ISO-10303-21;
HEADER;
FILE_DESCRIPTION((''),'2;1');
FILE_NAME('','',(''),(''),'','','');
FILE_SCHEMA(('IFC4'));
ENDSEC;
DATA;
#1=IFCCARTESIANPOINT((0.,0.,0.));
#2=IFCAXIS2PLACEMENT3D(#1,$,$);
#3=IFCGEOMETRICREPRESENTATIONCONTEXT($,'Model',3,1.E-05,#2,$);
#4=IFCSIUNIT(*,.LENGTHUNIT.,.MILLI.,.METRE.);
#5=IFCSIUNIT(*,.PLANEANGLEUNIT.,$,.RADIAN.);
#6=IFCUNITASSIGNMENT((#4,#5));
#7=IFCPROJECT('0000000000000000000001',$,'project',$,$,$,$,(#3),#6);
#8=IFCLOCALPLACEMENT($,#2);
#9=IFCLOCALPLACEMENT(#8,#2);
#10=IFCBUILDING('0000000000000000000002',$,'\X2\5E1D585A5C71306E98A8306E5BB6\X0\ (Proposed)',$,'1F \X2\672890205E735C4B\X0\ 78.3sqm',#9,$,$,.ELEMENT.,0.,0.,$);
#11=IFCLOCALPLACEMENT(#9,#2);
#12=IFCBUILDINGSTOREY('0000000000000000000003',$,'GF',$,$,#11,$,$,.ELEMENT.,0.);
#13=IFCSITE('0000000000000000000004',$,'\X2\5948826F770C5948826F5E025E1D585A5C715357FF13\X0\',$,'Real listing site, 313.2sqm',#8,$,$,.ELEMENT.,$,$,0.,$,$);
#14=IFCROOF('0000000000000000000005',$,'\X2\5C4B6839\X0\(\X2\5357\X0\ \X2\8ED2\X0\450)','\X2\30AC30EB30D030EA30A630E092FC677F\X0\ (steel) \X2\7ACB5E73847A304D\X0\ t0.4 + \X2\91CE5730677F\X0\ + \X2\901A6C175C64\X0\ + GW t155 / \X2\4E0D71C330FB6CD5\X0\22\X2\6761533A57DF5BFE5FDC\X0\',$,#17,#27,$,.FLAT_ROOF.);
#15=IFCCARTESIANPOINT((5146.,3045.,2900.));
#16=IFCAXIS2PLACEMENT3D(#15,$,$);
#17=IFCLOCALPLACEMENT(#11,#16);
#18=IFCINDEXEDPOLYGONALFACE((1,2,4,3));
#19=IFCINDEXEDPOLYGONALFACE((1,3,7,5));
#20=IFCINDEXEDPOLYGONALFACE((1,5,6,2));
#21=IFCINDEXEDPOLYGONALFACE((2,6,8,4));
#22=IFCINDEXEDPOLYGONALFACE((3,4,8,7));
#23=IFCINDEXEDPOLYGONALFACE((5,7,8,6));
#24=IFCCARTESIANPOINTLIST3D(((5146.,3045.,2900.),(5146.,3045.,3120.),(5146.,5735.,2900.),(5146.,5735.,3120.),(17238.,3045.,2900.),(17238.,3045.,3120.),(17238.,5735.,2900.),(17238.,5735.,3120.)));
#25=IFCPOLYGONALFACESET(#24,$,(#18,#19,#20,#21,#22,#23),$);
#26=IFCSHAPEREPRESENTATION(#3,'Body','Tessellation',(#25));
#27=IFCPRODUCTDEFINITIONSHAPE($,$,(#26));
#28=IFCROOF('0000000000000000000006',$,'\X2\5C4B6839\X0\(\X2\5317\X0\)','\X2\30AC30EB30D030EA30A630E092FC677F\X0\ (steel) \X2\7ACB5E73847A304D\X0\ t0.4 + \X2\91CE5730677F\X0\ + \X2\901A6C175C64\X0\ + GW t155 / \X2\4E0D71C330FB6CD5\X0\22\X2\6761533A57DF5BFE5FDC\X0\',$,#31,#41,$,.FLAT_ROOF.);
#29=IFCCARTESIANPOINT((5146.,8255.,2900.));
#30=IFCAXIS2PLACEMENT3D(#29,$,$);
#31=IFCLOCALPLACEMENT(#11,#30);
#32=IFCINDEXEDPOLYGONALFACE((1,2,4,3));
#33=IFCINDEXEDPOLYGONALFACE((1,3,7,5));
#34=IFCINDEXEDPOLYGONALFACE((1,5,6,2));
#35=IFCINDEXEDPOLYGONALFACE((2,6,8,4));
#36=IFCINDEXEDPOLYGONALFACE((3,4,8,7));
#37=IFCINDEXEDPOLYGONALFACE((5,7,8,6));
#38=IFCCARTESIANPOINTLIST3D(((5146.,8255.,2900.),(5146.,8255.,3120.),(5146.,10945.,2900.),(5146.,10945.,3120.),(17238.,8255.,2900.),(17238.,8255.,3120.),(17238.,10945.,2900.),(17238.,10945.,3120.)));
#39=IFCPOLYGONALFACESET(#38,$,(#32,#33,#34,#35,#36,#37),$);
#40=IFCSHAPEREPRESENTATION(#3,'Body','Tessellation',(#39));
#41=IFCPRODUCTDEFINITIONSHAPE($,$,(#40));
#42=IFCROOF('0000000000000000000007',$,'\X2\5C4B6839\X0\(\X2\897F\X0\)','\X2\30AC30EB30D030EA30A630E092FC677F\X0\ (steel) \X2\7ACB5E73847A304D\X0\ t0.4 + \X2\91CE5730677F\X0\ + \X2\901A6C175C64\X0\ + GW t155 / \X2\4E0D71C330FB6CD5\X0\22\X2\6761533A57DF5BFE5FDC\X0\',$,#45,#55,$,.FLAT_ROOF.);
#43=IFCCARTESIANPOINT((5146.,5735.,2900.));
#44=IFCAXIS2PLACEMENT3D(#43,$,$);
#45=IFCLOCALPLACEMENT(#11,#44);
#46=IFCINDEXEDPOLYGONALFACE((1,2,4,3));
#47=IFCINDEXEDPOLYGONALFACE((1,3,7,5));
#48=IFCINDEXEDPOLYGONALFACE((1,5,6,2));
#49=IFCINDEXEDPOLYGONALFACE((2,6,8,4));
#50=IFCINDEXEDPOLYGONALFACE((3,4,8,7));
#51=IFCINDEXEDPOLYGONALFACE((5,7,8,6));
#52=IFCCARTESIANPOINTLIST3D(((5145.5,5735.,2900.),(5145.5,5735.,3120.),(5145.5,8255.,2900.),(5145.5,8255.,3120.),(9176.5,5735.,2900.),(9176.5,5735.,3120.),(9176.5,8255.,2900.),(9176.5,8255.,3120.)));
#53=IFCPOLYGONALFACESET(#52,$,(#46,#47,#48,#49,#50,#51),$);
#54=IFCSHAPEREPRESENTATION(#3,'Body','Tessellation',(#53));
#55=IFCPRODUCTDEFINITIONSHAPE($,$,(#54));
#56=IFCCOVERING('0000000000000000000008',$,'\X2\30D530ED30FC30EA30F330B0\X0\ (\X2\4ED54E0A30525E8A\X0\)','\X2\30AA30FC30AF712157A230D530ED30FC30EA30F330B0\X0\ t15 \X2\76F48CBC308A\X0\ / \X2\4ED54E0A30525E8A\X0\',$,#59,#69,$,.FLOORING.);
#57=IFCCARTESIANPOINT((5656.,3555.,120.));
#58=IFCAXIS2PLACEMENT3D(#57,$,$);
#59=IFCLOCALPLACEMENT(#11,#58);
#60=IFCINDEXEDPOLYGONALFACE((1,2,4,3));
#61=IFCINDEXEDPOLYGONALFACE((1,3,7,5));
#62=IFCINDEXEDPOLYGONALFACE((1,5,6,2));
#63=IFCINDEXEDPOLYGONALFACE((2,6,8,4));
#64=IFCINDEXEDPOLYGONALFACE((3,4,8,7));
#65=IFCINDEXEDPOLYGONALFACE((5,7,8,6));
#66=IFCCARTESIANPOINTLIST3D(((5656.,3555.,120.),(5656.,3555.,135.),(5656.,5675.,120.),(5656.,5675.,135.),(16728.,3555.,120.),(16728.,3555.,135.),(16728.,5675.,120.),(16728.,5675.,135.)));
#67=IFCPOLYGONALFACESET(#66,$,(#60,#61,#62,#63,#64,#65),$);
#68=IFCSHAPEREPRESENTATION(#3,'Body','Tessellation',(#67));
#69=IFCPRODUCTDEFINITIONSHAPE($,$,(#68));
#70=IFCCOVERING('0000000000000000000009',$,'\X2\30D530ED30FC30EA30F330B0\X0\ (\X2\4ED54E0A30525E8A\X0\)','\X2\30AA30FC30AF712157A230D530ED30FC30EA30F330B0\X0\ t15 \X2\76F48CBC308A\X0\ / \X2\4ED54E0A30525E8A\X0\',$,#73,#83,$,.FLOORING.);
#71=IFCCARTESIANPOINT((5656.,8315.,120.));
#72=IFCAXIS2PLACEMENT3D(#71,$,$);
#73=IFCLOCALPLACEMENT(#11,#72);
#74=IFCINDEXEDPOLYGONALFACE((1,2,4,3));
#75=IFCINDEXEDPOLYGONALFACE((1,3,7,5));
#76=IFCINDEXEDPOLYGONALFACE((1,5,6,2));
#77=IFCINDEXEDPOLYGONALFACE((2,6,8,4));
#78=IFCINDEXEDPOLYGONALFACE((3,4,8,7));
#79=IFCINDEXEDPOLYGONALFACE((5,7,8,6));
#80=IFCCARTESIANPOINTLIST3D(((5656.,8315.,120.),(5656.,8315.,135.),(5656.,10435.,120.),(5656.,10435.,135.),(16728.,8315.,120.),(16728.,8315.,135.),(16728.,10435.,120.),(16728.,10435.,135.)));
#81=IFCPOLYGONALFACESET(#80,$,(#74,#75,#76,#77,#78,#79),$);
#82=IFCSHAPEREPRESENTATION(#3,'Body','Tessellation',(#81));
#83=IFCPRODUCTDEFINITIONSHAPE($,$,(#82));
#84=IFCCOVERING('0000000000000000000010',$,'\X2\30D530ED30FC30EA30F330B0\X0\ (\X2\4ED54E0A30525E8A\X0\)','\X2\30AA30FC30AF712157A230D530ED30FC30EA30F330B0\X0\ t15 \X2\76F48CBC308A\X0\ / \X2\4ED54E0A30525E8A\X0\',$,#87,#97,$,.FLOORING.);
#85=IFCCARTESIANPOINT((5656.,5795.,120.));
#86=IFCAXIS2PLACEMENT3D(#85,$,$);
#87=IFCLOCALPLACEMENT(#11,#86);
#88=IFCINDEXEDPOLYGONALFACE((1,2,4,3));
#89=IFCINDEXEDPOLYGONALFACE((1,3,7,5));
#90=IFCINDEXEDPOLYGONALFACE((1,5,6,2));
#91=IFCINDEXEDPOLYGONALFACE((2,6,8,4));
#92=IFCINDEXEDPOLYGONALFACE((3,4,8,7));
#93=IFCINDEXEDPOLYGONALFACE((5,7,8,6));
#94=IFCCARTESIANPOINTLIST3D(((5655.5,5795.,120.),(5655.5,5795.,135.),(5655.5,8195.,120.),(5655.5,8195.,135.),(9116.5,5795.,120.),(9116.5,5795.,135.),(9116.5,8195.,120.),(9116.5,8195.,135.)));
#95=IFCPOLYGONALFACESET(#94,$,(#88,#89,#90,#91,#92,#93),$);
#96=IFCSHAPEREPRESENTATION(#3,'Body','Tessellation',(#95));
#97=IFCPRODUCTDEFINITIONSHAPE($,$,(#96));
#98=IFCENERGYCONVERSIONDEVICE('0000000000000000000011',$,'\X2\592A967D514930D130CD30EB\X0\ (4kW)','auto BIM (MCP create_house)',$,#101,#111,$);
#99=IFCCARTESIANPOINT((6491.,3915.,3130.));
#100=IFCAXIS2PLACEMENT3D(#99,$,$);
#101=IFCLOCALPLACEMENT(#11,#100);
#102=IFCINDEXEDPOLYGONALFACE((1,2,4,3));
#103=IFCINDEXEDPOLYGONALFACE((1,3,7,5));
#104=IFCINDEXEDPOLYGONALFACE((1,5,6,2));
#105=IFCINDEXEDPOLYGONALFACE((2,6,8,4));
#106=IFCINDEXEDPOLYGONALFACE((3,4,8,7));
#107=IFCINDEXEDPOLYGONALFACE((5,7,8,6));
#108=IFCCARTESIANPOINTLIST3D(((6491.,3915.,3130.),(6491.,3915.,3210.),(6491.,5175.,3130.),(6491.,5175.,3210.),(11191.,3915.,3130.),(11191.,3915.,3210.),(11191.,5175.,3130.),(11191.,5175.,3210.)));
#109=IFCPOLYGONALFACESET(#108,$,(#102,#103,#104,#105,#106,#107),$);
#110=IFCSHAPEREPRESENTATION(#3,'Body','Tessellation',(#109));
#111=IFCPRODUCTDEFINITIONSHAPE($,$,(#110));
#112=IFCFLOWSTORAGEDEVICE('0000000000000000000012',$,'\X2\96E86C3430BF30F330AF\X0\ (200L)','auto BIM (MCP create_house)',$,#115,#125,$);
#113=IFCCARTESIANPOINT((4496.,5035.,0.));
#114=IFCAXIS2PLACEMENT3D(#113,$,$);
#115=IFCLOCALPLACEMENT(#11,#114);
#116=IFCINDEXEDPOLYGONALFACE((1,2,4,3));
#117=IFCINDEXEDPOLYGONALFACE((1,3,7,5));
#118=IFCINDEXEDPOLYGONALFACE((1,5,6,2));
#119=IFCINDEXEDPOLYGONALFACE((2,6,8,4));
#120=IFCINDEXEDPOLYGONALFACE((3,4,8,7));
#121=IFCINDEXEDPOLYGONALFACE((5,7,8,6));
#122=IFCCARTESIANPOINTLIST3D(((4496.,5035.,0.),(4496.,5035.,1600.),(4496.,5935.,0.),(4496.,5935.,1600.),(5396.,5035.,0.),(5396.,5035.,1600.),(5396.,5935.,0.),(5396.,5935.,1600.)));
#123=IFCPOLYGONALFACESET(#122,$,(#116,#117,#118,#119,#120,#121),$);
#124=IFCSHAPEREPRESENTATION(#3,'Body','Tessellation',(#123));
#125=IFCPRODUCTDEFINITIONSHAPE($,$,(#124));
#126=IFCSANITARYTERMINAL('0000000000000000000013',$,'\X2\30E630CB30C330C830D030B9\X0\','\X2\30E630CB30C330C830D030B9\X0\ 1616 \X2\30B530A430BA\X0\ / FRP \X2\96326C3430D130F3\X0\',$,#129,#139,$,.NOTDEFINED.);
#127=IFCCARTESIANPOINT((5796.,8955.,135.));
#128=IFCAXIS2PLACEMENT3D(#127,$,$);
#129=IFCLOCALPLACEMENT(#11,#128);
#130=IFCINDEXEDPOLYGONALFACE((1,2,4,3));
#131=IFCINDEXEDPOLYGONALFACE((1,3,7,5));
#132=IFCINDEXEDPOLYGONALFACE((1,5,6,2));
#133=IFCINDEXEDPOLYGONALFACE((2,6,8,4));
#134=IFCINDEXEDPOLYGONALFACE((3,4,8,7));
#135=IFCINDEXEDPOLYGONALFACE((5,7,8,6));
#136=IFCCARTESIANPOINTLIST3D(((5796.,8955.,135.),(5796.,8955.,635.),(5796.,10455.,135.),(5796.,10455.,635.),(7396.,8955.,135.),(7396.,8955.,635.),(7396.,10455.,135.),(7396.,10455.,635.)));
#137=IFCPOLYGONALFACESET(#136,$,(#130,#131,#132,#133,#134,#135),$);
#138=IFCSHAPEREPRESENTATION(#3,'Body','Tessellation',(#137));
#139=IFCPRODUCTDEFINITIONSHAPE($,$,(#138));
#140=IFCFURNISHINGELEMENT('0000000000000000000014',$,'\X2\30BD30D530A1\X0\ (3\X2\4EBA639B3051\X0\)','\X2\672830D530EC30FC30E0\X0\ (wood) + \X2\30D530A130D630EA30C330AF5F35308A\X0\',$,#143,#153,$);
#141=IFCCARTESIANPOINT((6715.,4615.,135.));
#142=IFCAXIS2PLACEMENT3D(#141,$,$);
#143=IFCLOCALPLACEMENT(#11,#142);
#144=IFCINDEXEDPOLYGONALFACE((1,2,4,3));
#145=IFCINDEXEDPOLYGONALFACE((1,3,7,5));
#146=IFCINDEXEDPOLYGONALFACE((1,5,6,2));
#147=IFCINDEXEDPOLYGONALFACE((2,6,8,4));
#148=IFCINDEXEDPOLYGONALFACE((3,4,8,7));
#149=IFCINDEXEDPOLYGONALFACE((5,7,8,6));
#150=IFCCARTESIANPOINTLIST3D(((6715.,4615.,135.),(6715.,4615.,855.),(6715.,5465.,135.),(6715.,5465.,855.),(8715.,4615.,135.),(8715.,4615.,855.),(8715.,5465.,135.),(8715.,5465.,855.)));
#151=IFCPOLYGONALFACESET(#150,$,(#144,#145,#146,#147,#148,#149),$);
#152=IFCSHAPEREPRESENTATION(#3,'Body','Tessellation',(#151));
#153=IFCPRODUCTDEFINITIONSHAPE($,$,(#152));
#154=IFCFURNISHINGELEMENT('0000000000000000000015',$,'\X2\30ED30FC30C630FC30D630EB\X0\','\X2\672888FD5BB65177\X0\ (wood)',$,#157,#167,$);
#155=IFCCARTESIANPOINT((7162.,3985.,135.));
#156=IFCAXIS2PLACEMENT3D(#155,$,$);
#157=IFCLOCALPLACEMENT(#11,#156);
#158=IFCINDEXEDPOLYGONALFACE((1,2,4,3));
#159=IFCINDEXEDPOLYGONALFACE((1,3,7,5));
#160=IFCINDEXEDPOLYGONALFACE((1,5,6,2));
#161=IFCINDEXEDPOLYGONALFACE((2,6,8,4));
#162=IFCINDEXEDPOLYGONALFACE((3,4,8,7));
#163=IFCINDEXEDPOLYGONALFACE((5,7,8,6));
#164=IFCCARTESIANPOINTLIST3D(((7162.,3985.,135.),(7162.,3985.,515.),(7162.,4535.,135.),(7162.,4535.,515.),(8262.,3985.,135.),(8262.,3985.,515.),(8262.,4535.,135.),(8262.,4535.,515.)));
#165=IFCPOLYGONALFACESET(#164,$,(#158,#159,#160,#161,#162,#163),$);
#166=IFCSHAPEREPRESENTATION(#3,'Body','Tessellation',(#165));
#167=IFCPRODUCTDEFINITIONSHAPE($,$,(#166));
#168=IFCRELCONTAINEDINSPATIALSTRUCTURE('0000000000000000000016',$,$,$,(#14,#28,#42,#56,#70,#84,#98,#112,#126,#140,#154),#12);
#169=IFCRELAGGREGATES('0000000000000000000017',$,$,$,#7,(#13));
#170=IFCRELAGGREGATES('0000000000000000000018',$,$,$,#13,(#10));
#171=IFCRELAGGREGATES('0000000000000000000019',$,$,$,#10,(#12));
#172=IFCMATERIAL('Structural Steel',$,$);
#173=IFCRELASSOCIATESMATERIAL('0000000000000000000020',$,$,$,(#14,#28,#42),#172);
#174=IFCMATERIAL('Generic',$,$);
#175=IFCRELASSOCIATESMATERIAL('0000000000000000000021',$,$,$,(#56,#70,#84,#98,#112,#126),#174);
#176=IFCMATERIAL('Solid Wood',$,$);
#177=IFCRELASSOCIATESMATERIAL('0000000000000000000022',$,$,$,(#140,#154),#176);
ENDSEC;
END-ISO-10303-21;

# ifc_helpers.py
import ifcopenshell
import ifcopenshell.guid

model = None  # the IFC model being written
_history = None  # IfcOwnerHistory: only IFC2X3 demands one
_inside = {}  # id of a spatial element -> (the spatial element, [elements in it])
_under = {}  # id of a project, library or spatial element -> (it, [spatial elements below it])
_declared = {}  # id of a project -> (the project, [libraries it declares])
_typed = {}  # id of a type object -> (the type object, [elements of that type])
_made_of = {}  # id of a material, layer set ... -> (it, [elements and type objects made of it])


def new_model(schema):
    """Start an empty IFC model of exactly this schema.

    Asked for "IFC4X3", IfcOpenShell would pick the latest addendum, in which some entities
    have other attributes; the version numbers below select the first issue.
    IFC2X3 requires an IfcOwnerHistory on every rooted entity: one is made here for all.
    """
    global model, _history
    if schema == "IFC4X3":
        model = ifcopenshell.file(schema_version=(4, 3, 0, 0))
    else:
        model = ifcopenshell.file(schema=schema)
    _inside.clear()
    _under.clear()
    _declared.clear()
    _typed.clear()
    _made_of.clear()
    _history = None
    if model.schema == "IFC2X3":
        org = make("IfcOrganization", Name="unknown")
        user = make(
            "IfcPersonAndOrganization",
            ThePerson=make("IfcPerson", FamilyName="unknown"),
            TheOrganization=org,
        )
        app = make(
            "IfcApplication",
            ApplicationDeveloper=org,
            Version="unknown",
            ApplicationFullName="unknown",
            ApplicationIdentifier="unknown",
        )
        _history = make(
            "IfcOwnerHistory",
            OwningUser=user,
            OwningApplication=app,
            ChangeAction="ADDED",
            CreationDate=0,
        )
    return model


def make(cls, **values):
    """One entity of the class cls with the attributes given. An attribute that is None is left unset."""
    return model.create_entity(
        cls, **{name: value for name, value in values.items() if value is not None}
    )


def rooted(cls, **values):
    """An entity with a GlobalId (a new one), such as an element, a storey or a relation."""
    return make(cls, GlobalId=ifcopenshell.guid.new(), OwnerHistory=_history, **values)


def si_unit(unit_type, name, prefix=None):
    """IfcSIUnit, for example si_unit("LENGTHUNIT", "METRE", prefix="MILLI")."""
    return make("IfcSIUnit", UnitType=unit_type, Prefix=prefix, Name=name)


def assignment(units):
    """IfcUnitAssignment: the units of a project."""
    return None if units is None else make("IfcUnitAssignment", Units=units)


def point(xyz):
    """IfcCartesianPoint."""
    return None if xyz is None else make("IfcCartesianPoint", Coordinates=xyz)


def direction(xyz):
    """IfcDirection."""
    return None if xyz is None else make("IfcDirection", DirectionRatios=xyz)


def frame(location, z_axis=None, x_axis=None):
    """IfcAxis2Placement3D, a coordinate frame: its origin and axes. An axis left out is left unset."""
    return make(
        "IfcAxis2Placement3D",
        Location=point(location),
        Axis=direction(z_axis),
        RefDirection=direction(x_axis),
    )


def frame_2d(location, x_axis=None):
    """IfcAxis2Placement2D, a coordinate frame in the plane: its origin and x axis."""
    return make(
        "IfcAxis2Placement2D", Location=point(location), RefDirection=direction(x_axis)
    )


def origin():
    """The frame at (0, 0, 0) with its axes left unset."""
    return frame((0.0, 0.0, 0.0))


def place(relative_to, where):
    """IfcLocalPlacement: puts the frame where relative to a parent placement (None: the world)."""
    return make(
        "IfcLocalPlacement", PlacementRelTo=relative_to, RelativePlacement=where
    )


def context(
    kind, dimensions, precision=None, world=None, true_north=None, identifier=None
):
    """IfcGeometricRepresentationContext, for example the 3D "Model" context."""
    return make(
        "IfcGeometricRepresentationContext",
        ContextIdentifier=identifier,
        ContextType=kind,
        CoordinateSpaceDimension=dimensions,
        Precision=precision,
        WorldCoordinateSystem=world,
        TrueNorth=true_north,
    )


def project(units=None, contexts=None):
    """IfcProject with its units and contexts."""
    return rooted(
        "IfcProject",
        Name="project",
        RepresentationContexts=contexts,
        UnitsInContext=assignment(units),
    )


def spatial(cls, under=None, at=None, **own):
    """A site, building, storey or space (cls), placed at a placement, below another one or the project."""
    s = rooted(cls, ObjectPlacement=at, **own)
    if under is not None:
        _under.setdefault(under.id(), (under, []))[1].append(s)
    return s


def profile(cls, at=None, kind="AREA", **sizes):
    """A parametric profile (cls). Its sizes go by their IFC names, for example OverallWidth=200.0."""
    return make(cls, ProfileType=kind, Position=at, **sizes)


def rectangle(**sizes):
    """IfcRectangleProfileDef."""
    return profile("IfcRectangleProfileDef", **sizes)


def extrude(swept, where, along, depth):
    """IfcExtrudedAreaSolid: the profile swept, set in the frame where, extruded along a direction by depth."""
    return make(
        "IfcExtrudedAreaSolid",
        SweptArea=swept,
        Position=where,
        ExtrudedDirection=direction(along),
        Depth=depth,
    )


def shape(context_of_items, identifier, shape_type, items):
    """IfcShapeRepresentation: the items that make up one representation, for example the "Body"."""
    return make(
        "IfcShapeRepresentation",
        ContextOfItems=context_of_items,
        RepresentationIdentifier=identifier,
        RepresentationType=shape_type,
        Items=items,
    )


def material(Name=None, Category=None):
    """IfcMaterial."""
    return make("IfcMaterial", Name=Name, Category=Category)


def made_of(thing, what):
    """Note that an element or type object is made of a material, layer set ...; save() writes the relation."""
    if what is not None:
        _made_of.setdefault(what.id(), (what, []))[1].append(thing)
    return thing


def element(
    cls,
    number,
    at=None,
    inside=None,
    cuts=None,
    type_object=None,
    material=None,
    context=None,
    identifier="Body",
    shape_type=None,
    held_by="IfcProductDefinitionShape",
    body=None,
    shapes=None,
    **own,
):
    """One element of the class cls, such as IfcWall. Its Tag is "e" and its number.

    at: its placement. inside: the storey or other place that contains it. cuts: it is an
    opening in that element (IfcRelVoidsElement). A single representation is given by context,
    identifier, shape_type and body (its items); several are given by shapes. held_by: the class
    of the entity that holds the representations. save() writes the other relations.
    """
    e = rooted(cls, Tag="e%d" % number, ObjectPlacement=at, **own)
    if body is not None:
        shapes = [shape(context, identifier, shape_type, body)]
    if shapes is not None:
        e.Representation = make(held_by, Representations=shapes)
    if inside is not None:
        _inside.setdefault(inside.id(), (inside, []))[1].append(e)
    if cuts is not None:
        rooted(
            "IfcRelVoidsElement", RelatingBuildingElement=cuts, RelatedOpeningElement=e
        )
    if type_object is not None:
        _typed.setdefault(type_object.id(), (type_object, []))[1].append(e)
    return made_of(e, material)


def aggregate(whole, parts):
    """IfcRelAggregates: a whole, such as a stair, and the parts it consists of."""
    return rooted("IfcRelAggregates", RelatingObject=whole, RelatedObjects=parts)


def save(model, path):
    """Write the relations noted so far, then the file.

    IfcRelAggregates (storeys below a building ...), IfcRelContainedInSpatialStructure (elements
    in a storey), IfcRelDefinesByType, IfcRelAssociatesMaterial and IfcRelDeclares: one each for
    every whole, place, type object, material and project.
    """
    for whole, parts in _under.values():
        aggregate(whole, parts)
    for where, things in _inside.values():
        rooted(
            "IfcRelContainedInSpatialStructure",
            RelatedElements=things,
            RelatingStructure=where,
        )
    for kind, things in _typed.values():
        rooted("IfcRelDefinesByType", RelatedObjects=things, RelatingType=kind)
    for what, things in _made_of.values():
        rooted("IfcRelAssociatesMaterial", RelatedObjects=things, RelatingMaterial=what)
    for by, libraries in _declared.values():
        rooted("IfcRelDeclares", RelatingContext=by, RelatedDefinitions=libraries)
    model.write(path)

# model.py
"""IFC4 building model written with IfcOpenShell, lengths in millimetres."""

from ifc_helpers import new_model, si_unit, frame, frame_2d, origin, place, context, project, spatial, rectangle, extrude, material, element, save


model = new_model("IFC4")

# Units and contexts
model_context = context("Model", 3, precision=1e-05, world=origin())
ifc_project = project(units=[si_unit("LENGTHUNIT", "METRE", prefix="MILLI"), si_unit("PLANEANGLEUNIT", "RADIAN")], contexts=[model_context])

# Site, building, storey
site_placement = place(None, origin())
site = spatial("IfcSite", under=ifc_project, at=site_placement, Name="奈良県奈良市帝塚山南３", ObjectType="Real listing site, 313.2sqm", CompositionType="ELEMENT", RefElevation=0.0)
building_placement = place(site_placement, origin())
building = spatial("IfcBuilding", under=site, at=building_placement, Name="帝塚山の風の家 (Proposed)", ObjectType="1F 木造平屋 78.3sqm", CompositionType="ELEMENT", ElevationOfRefHeight=0.0, ElevationOfTerrain=0.0)
storey_placement = place(building_placement, origin())
storey = spatial("IfcBuildingStorey", under=building, at=storey_placement, Name="GF", CompositionType="ELEMENT", Elevation=0.0)

# Shared definitions
ifc_material_1 = material(Name="Solid Wood")

# Roofs
ifc_material_2 = material(Name="Structural Steel")
roof_1_placement = place(storey_placement, frame((5146.0, 3045.0, 2900.0)))
element("IfcRoof", 1, at=roof_1_placement, inside=storey, material=ifc_material_2, Name="屋根(南 軒450)", Description="ガルバリウム鋼板 (steel) 立平葺き t0.4 + 野地板 + 通気層 + GW t155 / 不燃・法22条区域対応", PredefinedType="FLAT_ROOF", context=model_context, shape_type="SweptSolid", body=[
    extrude(rectangle(XDim=12092.0, YDim=2690.0, at=frame_2d((6046.0, 1345.0))), frame((5146.0, 3045.0, 2900.0)), (0.0, 0.0, 1.0), 220.0),
])
roof_2_placement = place(storey_placement, frame((5146.0, 8255.0, 2900.0)))
element("IfcRoof", 2, at=roof_2_placement, inside=storey, material=ifc_material_2, Name="屋根(北)", Description="ガルバリウム鋼板 (steel) 立平葺き t0.4 + 野地板 + 通気層 + GW t155 / 不燃・法22条区域対応", PredefinedType="FLAT_ROOF", context=model_context, shape_type="SweptSolid", body=[
    extrude(rectangle(XDim=12092.0, YDim=2690.0, at=frame_2d((6046.0, 1345.0))), frame((5146.0, 8255.0, 2900.0)), (0.0, 0.0, 1.0), 220.0),
])
roof_3_placement = place(storey_placement, frame((5146.0, 5735.0, 2900.0)))
element("IfcRoof", 3, at=roof_3_placement, inside=storey, material=ifc_material_2, Name="屋根(西)", Description="ガルバリウム鋼板 (steel) 立平葺き t0.4 + 野地板 + 通気層 + GW t155 / 不燃・法22条区域対応", PredefinedType="FLAT_ROOF", context=model_context, shape_type="SweptSolid", body=[
    extrude(rectangle(XDim=4031.0, YDim=2520.0, at=frame_2d((2015.0, 1260.0))), frame((5146.0, 5735.0, 2900.0)), (0.0, 0.0, 1.0), 220.0),
])

# Coverings
ifc_material_3 = material(Name="Generic")
covering_1_placement = place(storey_placement, frame((5656.0, 3555.0, 120.0)))
element("IfcCovering", 4, at=covering_1_placement, inside=storey, material=ifc_material_3, Name="フローリング (仕上げ床)", Description="オーク無垢フローリング t15 直貼り / 仕上げ床", PredefinedType="FLOORING", context=model_context, shape_type="SweptSolid", body=[
    extrude(rectangle(XDim=11072.0, YDim=2120.0, at=frame_2d((5536.0, 1060.0))), frame((5656.0, 3555.0, 120.0)), (0.0, 0.0, 1.0), 15.0),
])
covering_2_placement = place(storey_placement, frame((5656.0, 8315.0, 120.0)))
element("IfcCovering", 5, at=covering_2_placement, inside=storey, material=ifc_material_3, Name="フローリング (仕上げ床)", Description="オーク無垢フローリング t15 直貼り / 仕上げ床", PredefinedType="FLOORING", context=model_context, shape_type="SweptSolid", body=[
    extrude(rectangle(XDim=11072.0, YDim=2120.0, at=frame_2d((5536.0, 1060.0))), frame((5656.0, 8315.0, 120.0)), (0.0, 0.0, 1.0), 15.0),
])
covering_3_placement = place(storey_placement, frame((5656.0, 5795.0, 120.0)))
element("IfcCovering", 6, at=covering_3_placement, inside=storey, material=ifc_material_3, Name="フローリング (仕上げ床)", Description="オーク無垢フローリング t15 直貼り / 仕上げ床", PredefinedType="FLOORING", context=model_context, shape_type="SweptSolid", body=[
    extrude(rectangle(XDim=3461.0, YDim=2400.0, at=frame_2d((1730.0, 1200.0))), frame((5656.0, 5795.0, 120.0)), (0.0, 0.0, 1.0), 15.0),
])

# Energy conversion device
energy_conversion_device_placement = place(storey_placement, frame((6491.0, 3915.0, 3130.0)))
element("IfcEnergyConversionDevice", 7, at=energy_conversion_device_placement, inside=storey, material=ifc_material_3, Name="太陽光パネル (4kW)", Description="auto BIM (MCP create_house)", context=model_context, shape_type="SweptSolid", body=[
    extrude(rectangle(XDim=4700.0, YDim=1260.0, at=frame_2d((2350.0, 630.0))), frame((6491.0, 3915.0, 3130.0)), (0.0, 0.0, 1.0), 80.0),
])

# Flow storage device
flow_storage_device_placement = place(storey_placement, frame((4496.0, 5035.0, 0.0)))
element("IfcFlowStorageDevice", 8, at=flow_storage_device_placement, inside=storey, material=ifc_material_3, Name="雨水タンク (200L)", Description="auto BIM (MCP create_house)", context=model_context, shape_type="SweptSolid", body=[
    extrude(rectangle(XDim=900.0, YDim=900.0, at=frame_2d((450.0, 450.0))), frame((4496.0, 5035.0, 0.0)), (0.0, 0.0, 1.0), 1600.0),
])

# Sanitary terminal
sanitary_terminal_placement = place(storey_placement, frame((5796.0, 8955.0, 135.0)))
element("IfcSanitaryTerminal", 9, at=sanitary_terminal_placement, inside=storey, material=ifc_material_3, Name="ユニットバス", Description="ユニットバス 1616 サイズ / FRP 防水パン", PredefinedType="NOTDEFINED", context=model_context, shape_type="SweptSolid", body=[
    extrude(rectangle(XDim=1600.0, YDim=1500.0, at=frame_2d((800.0, 750.0))), frame((5796.0, 8955.0, 135.0)), (0.0, 0.0, 1.0), 500.0),
])

# Furnishing elements
furnishing_1_placement = place(storey_placement, frame((6715.0, 4615.0, 135.0)))
element("IfcFurnishingElement", 10, at=furnishing_1_placement, inside=storey, material=ifc_material_1, Name="ソファ (3人掛け)", Description="木フレーム (wood) + ファブリック張り", context=model_context, shape_type="SweptSolid", body=[
    extrude(rectangle(XDim=2000.0, YDim=850.0, at=frame_2d((1000.0, 425.0))), frame((6715.0, 4615.0, 135.0)), (0.0, 0.0, 1.0), 720.0),
])
furnishing_2_placement = place(storey_placement, frame((7162.0, 3985.0, 135.0)))
element("IfcFurnishingElement", 11, at=furnishing_2_placement, inside=storey, material=ifc_material_1, Name="ローテーブル", Description="木製家具 (wood)", context=model_context, shape_type="SweptSolid", body=[
    extrude(rectangle(XDim=1100.0, YDim=550.0, at=frame_2d((550.0, 275.0))), frame((7162.0, 3985.0, 135.0)), (0.0, 0.0, 1.0), 380.0),
])

save(model, "model.ifc")
